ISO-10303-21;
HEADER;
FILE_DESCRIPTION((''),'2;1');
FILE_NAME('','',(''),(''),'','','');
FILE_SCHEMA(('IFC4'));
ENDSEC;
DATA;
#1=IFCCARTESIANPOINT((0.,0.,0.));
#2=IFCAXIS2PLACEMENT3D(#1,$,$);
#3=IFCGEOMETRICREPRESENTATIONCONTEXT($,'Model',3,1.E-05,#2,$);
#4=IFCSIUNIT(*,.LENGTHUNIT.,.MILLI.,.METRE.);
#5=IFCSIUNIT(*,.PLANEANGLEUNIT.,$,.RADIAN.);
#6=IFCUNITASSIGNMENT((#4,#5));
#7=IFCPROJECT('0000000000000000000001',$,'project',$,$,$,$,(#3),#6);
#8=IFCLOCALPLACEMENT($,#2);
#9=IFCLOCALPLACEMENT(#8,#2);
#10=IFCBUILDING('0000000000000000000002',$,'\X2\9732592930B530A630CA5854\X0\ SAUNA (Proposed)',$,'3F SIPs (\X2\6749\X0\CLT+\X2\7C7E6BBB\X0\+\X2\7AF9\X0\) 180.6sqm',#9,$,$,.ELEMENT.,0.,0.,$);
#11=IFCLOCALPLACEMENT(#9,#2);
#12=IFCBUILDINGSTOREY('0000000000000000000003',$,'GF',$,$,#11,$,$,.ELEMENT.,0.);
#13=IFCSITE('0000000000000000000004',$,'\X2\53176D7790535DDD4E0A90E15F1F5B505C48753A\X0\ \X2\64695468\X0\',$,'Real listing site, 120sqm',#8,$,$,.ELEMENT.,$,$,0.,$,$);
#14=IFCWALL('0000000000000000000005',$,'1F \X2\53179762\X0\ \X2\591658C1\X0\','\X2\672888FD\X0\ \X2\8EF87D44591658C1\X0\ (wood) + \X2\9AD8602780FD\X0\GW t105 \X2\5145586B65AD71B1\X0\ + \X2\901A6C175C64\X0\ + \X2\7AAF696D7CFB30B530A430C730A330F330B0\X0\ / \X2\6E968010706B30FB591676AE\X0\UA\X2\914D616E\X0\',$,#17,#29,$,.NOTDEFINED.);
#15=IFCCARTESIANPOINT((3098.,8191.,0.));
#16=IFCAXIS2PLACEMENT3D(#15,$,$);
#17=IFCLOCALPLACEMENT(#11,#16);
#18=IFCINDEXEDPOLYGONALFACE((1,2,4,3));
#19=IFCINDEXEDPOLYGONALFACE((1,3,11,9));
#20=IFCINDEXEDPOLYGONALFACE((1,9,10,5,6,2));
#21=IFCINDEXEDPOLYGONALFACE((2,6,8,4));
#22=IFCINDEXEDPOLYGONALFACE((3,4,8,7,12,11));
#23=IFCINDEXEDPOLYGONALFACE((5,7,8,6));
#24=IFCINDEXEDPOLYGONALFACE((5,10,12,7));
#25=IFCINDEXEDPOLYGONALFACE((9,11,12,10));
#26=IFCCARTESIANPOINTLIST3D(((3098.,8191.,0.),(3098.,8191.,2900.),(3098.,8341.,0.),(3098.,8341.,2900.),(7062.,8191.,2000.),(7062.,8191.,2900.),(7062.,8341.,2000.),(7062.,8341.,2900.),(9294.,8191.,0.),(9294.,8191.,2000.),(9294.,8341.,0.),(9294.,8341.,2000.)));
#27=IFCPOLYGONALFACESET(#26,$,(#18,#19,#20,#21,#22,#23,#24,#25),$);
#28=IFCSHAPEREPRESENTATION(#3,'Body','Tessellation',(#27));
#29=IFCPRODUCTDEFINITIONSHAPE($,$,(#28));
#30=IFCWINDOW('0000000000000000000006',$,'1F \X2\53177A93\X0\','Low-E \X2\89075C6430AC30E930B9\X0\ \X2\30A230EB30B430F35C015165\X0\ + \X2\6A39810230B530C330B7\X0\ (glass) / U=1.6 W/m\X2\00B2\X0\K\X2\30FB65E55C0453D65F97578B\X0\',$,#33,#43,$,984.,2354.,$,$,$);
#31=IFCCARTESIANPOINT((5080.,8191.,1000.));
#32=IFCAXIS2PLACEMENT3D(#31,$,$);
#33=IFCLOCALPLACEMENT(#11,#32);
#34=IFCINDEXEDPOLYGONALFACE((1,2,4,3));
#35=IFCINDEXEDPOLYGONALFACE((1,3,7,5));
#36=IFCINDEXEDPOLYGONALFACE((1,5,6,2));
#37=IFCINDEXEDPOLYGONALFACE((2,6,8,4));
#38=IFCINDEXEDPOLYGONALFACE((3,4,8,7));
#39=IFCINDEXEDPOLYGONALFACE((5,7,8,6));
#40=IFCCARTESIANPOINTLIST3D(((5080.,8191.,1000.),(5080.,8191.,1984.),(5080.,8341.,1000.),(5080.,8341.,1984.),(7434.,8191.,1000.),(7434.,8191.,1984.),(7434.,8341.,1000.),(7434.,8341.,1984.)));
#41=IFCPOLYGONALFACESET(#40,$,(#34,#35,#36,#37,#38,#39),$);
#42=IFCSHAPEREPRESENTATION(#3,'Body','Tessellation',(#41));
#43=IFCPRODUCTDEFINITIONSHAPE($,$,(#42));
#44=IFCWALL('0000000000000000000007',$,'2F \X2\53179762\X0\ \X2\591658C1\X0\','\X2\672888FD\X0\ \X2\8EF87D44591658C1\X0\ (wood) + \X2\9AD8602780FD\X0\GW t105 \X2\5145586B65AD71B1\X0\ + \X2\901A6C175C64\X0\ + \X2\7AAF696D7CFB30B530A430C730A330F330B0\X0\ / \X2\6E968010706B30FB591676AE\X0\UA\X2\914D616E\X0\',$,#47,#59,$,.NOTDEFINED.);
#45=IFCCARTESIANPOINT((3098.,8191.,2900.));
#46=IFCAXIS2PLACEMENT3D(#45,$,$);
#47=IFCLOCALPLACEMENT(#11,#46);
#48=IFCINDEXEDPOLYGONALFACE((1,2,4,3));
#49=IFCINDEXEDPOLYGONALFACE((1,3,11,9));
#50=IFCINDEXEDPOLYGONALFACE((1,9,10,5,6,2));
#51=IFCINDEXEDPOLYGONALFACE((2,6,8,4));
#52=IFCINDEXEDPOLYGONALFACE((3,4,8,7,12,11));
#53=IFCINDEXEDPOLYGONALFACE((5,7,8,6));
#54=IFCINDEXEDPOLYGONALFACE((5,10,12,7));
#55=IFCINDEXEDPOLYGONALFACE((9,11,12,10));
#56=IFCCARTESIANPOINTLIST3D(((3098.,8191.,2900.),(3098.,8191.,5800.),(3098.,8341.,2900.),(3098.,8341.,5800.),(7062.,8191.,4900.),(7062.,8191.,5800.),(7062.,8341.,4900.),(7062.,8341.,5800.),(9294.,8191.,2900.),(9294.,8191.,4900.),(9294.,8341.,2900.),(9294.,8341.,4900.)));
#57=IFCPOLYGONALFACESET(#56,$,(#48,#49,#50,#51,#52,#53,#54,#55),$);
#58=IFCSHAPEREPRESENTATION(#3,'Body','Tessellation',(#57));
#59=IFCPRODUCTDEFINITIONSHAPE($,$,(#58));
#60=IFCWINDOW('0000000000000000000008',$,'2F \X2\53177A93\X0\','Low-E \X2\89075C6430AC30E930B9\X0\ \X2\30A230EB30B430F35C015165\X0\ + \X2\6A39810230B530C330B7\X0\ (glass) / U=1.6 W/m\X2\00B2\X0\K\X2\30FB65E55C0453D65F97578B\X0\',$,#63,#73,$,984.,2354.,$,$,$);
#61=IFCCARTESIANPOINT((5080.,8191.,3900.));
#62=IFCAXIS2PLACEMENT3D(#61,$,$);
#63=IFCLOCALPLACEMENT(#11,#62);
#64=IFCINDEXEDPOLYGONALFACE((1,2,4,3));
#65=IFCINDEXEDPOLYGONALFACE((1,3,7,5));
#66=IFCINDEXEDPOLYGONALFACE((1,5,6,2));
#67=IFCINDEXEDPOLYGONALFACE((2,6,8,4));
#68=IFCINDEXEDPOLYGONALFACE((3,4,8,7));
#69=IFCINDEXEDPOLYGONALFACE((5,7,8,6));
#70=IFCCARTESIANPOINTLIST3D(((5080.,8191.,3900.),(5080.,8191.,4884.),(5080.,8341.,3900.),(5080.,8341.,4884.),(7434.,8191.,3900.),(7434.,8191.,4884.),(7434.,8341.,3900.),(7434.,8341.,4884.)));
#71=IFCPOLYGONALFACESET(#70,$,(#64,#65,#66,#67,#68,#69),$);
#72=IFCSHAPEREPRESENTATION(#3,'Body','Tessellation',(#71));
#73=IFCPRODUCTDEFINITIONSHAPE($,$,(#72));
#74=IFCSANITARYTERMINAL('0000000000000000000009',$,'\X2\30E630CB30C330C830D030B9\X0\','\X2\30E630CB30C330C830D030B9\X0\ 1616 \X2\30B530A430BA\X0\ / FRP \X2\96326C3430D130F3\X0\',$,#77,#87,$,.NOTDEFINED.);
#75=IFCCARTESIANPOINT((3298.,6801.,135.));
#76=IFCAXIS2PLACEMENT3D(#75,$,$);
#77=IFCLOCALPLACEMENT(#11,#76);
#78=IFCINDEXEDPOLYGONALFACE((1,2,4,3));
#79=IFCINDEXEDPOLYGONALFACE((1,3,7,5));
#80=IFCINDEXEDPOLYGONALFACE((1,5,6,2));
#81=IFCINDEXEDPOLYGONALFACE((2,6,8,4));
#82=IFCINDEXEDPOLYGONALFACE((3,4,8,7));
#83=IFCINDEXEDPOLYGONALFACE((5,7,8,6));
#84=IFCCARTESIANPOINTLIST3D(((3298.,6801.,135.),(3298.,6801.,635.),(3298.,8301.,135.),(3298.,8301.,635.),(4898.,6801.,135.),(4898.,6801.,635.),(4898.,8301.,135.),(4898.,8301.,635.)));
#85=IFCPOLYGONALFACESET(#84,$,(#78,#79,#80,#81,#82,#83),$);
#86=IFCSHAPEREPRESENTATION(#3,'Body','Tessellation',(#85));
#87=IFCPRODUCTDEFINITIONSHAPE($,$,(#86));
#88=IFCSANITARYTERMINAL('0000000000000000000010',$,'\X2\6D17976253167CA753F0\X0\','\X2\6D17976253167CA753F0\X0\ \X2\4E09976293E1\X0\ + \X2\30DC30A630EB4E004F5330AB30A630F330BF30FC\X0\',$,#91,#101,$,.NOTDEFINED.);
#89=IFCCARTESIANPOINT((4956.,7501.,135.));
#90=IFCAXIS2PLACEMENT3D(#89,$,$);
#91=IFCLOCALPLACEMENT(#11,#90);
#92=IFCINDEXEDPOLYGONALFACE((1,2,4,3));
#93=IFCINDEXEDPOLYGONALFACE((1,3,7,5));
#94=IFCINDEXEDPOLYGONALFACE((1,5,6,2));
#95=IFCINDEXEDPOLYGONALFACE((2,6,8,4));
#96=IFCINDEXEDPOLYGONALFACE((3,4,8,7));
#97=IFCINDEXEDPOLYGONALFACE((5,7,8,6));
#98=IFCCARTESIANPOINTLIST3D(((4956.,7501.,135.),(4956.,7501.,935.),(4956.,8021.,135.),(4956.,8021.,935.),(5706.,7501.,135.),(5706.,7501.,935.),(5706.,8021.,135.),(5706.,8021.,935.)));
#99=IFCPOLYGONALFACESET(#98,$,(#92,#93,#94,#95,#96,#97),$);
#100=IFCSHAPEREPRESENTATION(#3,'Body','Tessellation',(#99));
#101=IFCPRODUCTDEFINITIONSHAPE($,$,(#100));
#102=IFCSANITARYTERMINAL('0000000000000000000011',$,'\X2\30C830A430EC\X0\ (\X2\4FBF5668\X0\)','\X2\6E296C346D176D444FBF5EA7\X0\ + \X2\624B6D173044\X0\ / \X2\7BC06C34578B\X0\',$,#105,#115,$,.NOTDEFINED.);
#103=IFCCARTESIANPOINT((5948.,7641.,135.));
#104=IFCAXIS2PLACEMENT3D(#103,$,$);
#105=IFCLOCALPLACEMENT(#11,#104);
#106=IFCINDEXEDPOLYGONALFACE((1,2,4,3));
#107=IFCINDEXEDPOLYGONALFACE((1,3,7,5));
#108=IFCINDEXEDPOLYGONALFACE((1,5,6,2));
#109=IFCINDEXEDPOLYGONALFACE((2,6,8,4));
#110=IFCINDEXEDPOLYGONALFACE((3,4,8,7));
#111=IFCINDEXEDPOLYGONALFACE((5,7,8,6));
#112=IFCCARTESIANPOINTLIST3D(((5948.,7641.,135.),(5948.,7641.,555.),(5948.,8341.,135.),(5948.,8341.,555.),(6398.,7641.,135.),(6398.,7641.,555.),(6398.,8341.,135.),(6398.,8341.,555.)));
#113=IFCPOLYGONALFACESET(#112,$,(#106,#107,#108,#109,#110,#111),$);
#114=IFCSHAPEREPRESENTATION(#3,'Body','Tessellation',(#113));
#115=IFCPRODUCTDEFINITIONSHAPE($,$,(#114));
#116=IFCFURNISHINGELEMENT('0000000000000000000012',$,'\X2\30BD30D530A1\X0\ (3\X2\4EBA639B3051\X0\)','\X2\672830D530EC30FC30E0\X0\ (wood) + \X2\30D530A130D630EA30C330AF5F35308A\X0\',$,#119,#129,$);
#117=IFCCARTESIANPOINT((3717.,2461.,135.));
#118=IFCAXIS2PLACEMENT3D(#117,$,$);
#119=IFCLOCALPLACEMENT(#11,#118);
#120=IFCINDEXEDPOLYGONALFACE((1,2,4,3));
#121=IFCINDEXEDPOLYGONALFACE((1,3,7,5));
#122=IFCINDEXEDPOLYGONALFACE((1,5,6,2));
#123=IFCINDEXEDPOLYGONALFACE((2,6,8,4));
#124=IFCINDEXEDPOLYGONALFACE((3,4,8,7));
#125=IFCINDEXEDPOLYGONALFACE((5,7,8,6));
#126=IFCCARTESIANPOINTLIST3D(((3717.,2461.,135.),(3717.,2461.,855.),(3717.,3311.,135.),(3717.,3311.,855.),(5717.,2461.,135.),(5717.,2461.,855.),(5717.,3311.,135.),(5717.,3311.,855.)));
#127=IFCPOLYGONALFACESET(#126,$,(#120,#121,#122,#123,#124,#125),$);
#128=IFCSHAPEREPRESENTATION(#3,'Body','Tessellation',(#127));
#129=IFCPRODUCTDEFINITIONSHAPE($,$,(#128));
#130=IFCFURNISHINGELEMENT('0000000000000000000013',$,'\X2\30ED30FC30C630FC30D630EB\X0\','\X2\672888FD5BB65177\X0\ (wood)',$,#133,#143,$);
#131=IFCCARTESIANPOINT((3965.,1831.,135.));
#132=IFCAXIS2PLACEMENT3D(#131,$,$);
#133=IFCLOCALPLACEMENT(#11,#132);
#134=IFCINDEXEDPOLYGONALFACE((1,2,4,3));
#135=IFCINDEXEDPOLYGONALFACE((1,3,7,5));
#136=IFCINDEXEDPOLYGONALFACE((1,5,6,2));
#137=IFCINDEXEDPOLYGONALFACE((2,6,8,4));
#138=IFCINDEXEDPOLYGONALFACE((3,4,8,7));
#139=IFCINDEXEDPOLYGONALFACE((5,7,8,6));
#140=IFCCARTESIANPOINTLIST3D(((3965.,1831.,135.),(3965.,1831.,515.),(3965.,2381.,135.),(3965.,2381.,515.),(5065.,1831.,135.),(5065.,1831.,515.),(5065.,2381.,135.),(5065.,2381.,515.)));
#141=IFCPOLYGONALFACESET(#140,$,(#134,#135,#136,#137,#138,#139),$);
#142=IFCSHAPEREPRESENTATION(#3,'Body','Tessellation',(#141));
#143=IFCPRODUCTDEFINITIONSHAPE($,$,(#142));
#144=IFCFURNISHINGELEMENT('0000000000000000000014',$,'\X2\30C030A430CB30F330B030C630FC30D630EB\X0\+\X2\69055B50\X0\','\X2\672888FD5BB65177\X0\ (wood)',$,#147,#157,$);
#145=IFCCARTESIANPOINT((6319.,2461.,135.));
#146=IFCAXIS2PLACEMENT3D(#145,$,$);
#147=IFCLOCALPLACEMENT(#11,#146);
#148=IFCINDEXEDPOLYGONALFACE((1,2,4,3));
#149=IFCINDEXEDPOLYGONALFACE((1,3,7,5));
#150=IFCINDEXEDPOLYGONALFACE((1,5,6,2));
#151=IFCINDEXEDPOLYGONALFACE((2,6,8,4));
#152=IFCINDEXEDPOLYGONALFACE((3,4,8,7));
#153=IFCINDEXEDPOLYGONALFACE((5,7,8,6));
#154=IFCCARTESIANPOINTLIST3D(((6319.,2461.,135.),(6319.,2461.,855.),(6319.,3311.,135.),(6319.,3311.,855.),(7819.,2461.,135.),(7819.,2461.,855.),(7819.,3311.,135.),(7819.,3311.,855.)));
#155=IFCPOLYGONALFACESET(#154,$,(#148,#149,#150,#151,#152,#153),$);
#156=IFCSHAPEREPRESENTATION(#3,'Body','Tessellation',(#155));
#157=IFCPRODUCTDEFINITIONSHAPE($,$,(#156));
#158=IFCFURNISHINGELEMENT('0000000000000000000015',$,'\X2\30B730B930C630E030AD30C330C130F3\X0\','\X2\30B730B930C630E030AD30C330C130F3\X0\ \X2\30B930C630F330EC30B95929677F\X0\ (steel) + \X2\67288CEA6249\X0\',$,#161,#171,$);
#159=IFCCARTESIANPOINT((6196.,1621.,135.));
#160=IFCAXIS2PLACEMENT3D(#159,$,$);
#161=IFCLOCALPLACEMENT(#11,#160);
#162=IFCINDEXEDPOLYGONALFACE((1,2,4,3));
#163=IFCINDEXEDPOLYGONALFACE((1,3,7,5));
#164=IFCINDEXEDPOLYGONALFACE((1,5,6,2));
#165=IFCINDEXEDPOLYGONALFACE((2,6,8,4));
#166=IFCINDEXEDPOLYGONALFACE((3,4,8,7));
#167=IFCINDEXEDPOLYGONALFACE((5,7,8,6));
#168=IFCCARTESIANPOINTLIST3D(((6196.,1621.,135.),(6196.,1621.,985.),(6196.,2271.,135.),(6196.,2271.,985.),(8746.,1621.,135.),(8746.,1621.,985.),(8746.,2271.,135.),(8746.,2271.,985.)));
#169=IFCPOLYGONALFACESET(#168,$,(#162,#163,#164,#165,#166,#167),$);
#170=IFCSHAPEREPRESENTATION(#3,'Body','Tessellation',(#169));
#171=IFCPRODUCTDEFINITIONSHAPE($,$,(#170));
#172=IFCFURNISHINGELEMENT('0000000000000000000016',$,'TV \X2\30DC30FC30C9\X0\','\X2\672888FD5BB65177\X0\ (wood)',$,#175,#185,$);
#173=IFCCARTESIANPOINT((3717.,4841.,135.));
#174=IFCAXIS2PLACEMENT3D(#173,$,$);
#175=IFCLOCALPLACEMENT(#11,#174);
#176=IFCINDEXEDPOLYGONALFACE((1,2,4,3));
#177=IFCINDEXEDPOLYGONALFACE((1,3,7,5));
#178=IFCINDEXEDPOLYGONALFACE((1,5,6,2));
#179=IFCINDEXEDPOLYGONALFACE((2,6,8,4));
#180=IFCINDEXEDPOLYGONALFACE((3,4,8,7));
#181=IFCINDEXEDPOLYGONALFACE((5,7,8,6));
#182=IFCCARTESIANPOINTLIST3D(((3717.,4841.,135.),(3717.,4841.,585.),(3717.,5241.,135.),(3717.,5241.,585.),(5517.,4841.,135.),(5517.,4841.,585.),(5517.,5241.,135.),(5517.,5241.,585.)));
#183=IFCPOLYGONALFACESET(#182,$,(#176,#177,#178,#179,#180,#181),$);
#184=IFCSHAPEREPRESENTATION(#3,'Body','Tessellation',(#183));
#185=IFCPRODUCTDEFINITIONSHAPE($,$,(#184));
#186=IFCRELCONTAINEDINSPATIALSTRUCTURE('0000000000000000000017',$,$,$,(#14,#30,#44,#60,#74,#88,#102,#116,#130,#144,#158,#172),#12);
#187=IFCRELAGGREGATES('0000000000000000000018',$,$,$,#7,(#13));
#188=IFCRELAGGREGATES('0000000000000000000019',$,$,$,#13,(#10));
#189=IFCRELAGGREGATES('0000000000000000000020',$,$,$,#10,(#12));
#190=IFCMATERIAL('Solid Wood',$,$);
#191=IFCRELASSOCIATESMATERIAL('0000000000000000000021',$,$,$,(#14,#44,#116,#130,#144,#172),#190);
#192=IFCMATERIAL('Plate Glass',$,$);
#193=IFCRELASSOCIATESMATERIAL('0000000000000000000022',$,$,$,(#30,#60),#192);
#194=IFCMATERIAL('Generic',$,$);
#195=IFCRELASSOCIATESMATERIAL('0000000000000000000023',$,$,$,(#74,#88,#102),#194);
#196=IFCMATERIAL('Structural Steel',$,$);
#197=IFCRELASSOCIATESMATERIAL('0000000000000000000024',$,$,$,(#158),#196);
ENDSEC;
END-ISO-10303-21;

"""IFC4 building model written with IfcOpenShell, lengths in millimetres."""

from ifc_helpers import new_model, si_unit, frame, frame_2d, origin, place, context, project, spatial, rectangle, extrude, material, element, fill, save


model = new_model("IFC4")

# Units and contexts
model_context = context("Model", 3, precision=1e-05, world=origin())
ifc_project = project(units=[si_unit("LENGTHUNIT", "METRE", prefix="MILLI"), si_unit("PLANEANGLEUNIT", "RADIAN")], contexts=[model_context])

# Site, building, storey
site_placement = place(None, origin())
site = spatial("IfcSite", under=ifc_project, at=site_placement, Name="北海道川上郡弟子屈町 摩周", ObjectType="Real listing site, 120sqm", CompositionType="ELEMENT", RefElevation=0.0)
building_placement = place(site_placement, origin())
building = spatial("IfcBuilding", under=site, at=building_placement, Name="露天サウナ塔 SAUNA (Proposed)", ObjectType="3F SIPs (杉CLT+籾殻+竹) 180.6sqm", CompositionType="ELEMENT", ElevationOfRefHeight=0.0, ElevationOfTerrain=0.0)
storey_placement = place(building_placement, origin())
storey = spatial("IfcBuildingStorey", under=building, at=storey_placement, Name="GF", CompositionType="ELEMENT", Elevation=0.0)

# Wall, opening, window
ifc_material_1 = material(Name="Solid Wood")
wall_1_placement = place(storey_placement, frame((3098.0, 8191.0, 0.0)))
wall_1 = element("IfcWall", 1, at=wall_1_placement, inside=storey, material=ifc_material_1, Name="1F 北面 外壁", Description="木製 軸組外壁 (wood) + 高性能GW t105 充填断熱 + 通気層 + 窯業系サイディング / 準耐火・外皮UA配慮", PredefinedType="NOTDEFINED", context=model_context, shape_type="SweptSolid", body=[
    extrude(rectangle(XDim=6196.0, YDim=150.0, at=frame_2d((3098.0, 75.0))), frame((3098.0, 8191.0, 0.0)), (0.0, 0.0, 1.0), 2900.0),
])
opening_1_placement = place(storey_placement, frame((5080.0, 8191.0, 1000.0)))
opening_1 = element("IfcOpeningElement", 2, at=opening_1_placement, cuts=wall_1, PredefinedType="NOTDEFINED", context=model_context, shape_type="SweptSolid", body=[
    extrude(rectangle(XDim=2354.0, YDim=150.0, at=frame_2d((1177.0, 75.0))), frame((5080.0, 8191.0, 1000.0)), (0.0, 0.0, 1.0), 984.0),
])
ifc_material_2 = material(Name="Plate Glass")
window_1_placement = place(storey_placement, frame((5080.0, 8191.0, 1000.0)))
window_1 = element("IfcWindow", 3, at=window_1_placement, inside=storey, material=ifc_material_2, Name="1F 北窓", Description="Low-E 複層ガラス アルゴン封入 + 樹脂サッシ (glass) / U=1.6 W/m²K・日射取得型", OverallHeight=984.0, OverallWidth=2354.0, context=model_context, shape_type="SweptSolid", body=[
    extrude(rectangle(XDim=2354.0, YDim=150.0, at=frame_2d((1177.0, 75.0))), frame((5080.0, 8191.0, 1000.0)), (0.0, 0.0, 1.0), 984.0),
])
fill(opening_1, window_1)

# Wall, opening, window
wall_2_placement = place(storey_placement, frame((3098.0, 8191.0, 2900.0)))
wall_2 = element("IfcWall", 4, at=wall_2_placement, inside=storey, material=ifc_material_1, Name="2F 北面 外壁", Description="木製 軸組外壁 (wood) + 高性能GW t105 充填断熱 + 通気層 + 窯業系サイディング / 準耐火・外皮UA配慮", PredefinedType="NOTDEFINED", context=model_context, shape_type="SweptSolid", body=[
    extrude(rectangle(XDim=6196.0, YDim=150.0, at=frame_2d((3098.0, 75.0))), frame((3098.0, 8191.0, 2900.0)), (0.0, 0.0, 1.0), 2900.0),
])
opening_2_placement = place(storey_placement, frame((5080.0, 8191.0, 3900.0)))
opening_2 = element("IfcOpeningElement", 5, at=opening_2_placement, cuts=wall_2, PredefinedType="NOTDEFINED", context=model_context, shape_type="SweptSolid", body=[
    extrude(rectangle(XDim=2354.0, YDim=150.0, at=frame_2d((1177.0, 75.0))), frame((5080.0, 8191.0, 3900.0)), (0.0, 0.0, 1.0), 984.0),
])
window_2_placement = place(storey_placement, frame((5080.0, 8191.0, 3900.0)))
window_2 = element("IfcWindow", 6, at=window_2_placement, inside=storey, material=ifc_material_2, Name="2F 北窓", Description="Low-E 複層ガラス アルゴン封入 + 樹脂サッシ (glass) / U=1.6 W/m²K・日射取得型", OverallHeight=984.0, OverallWidth=2354.0, context=model_context, shape_type="SweptSolid", body=[
    extrude(rectangle(XDim=2354.0, YDim=150.0, at=frame_2d((1177.0, 75.0))), frame((5080.0, 8191.0, 3900.0)), (0.0, 0.0, 1.0), 984.0),
])
fill(opening_2, window_2)

# Sanitary terminals
ifc_material_3 = material(Name="Generic")
sanitary_terminal_1_placement = place(storey_placement, frame((3298.0, 6801.0, 135.0)))
element("IfcSanitaryTerminal", 7, at=sanitary_terminal_1_placement, inside=storey, material=ifc_material_3, Name="ユニットバス", Description="ユニットバス 1616 サイズ / FRP 防水パン", PredefinedType="NOTDEFINED", context=model_context, shape_type="SweptSolid", body=[
    extrude(rectangle(XDim=1600.0, YDim=1500.0, at=frame_2d((800.0, 750.0))), frame((3298.0, 6801.0, 135.0)), (0.0, 0.0, 1.0), 500.0),
])
sanitary_terminal_2_placement = place(storey_placement, frame((4956.0, 7501.0, 135.0)))
element("IfcSanitaryTerminal", 8, at=sanitary_terminal_2_placement, inside=storey, material=ifc_material_3, Name="洗面化粧台", Description="洗面化粧台 三面鏡 + ボウル一体カウンター", PredefinedType="NOTDEFINED", context=model_context, shape_type="SweptSolid", body=[
    extrude(rectangle(XDim=750.0, YDim=520.0, at=frame_2d((375.0, 260.0))), frame((4956.0, 7501.0, 135.0)), (0.0, 0.0, 1.0), 800.0),
])
sanitary_terminal_3_placement = place(storey_placement, frame((5948.0, 7641.0, 135.0)))
element("IfcSanitaryTerminal", 9, at=sanitary_terminal_3_placement, inside=storey, material=ifc_material_3, Name="トイレ (便器)", Description="温水洗浄便座 + 手洗い / 節水型", PredefinedType="NOTDEFINED", context=model_context, shape_type="SweptSolid", body=[
    extrude(rectangle(XDim=450.0, YDim=700.0, at=frame_2d((225.0, 350.0))), frame((5948.0, 7641.0, 135.0)), (0.0, 0.0, 1.0), 420.0),
])

# Furnishing elements
furnishing_1_placement = place(storey_placement, frame((3717.0, 2461.0, 135.0)))
element("IfcFurnishingElement", 10, at=furnishing_1_placement, inside=storey, material=ifc_material_1, Name="ソファ (3人掛け)", Description="木フレーム (wood) + ファブリック張り", context=model_context, shape_type="SweptSolid", body=[
    extrude(rectangle(XDim=2000.0, YDim=850.0, at=frame_2d((1000.0, 425.0))), frame((3717.0, 2461.0, 135.0)), (0.0, 0.0, 1.0), 720.0),
])
furnishing_2_placement = place(storey_placement, frame((3965.0, 1831.0, 135.0)))
element("IfcFurnishingElement", 11, at=furnishing_2_placement, inside=storey, material=ifc_material_1, Name="ローテーブル", Description="木製家具 (wood)", context=model_context, shape_type="SweptSolid", body=[
    extrude(rectangle(XDim=1100.0, YDim=550.0, at=frame_2d((550.0, 275.0))), frame((3965.0, 1831.0, 135.0)), (0.0, 0.0, 1.0), 380.0),
])
furnishing_3_placement = place(storey_placement, frame((6319.0, 2461.0, 135.0)))
element("IfcFurnishingElement", 12, at=furnishing_3_placement, inside=storey, material=ifc_material_1, Name="ダイニングテーブル+椅子", Description="木製家具 (wood)", context=model_context, shape_type="SweptSolid", body=[
    extrude(rectangle(XDim=1500.0, YDim=850.0, at=frame_2d((750.0, 425.0))), frame((6319.0, 2461.0, 135.0)), (0.0, 0.0, 1.0), 720.0),
])
ifc_material_4 = material(Name="Structural Steel")
furnishing_4_placement = place(storey_placement, frame((6196.0, 1621.0, 135.0)))
element("IfcFurnishingElement", 13, at=furnishing_4_placement, inside=storey, material=ifc_material_4, Name="システムキッチン", Description="システムキッチン ステンレス天板 (steel) + 木質扉", context=model_context, shape_type="SweptSolid", body=[
    extrude(rectangle(XDim=2550.0, YDim=650.0, at=frame_2d((1275.0, 325.0))), frame((6196.0, 1621.0, 135.0)), (0.0, 0.0, 1.0), 850.0),
])
furnishing_5_placement = place(storey_placement, frame((3717.0, 4841.0, 135.0)))
element("IfcFurnishingElement", 14, at=furnishing_5_placement, inside=storey, material=ifc_material_1, Name="TV ボード", Description="木製家具 (wood)", context=model_context, shape_type="SweptSolid", body=[
    extrude(rectangle(XDim=1800.0, YDim=400.0, at=frame_2d((900.0, 200.0))), frame((3717.0, 4841.0, 135.0)), (0.0, 0.0, 1.0), 450.0),
])

save(model, "model.ifc")
